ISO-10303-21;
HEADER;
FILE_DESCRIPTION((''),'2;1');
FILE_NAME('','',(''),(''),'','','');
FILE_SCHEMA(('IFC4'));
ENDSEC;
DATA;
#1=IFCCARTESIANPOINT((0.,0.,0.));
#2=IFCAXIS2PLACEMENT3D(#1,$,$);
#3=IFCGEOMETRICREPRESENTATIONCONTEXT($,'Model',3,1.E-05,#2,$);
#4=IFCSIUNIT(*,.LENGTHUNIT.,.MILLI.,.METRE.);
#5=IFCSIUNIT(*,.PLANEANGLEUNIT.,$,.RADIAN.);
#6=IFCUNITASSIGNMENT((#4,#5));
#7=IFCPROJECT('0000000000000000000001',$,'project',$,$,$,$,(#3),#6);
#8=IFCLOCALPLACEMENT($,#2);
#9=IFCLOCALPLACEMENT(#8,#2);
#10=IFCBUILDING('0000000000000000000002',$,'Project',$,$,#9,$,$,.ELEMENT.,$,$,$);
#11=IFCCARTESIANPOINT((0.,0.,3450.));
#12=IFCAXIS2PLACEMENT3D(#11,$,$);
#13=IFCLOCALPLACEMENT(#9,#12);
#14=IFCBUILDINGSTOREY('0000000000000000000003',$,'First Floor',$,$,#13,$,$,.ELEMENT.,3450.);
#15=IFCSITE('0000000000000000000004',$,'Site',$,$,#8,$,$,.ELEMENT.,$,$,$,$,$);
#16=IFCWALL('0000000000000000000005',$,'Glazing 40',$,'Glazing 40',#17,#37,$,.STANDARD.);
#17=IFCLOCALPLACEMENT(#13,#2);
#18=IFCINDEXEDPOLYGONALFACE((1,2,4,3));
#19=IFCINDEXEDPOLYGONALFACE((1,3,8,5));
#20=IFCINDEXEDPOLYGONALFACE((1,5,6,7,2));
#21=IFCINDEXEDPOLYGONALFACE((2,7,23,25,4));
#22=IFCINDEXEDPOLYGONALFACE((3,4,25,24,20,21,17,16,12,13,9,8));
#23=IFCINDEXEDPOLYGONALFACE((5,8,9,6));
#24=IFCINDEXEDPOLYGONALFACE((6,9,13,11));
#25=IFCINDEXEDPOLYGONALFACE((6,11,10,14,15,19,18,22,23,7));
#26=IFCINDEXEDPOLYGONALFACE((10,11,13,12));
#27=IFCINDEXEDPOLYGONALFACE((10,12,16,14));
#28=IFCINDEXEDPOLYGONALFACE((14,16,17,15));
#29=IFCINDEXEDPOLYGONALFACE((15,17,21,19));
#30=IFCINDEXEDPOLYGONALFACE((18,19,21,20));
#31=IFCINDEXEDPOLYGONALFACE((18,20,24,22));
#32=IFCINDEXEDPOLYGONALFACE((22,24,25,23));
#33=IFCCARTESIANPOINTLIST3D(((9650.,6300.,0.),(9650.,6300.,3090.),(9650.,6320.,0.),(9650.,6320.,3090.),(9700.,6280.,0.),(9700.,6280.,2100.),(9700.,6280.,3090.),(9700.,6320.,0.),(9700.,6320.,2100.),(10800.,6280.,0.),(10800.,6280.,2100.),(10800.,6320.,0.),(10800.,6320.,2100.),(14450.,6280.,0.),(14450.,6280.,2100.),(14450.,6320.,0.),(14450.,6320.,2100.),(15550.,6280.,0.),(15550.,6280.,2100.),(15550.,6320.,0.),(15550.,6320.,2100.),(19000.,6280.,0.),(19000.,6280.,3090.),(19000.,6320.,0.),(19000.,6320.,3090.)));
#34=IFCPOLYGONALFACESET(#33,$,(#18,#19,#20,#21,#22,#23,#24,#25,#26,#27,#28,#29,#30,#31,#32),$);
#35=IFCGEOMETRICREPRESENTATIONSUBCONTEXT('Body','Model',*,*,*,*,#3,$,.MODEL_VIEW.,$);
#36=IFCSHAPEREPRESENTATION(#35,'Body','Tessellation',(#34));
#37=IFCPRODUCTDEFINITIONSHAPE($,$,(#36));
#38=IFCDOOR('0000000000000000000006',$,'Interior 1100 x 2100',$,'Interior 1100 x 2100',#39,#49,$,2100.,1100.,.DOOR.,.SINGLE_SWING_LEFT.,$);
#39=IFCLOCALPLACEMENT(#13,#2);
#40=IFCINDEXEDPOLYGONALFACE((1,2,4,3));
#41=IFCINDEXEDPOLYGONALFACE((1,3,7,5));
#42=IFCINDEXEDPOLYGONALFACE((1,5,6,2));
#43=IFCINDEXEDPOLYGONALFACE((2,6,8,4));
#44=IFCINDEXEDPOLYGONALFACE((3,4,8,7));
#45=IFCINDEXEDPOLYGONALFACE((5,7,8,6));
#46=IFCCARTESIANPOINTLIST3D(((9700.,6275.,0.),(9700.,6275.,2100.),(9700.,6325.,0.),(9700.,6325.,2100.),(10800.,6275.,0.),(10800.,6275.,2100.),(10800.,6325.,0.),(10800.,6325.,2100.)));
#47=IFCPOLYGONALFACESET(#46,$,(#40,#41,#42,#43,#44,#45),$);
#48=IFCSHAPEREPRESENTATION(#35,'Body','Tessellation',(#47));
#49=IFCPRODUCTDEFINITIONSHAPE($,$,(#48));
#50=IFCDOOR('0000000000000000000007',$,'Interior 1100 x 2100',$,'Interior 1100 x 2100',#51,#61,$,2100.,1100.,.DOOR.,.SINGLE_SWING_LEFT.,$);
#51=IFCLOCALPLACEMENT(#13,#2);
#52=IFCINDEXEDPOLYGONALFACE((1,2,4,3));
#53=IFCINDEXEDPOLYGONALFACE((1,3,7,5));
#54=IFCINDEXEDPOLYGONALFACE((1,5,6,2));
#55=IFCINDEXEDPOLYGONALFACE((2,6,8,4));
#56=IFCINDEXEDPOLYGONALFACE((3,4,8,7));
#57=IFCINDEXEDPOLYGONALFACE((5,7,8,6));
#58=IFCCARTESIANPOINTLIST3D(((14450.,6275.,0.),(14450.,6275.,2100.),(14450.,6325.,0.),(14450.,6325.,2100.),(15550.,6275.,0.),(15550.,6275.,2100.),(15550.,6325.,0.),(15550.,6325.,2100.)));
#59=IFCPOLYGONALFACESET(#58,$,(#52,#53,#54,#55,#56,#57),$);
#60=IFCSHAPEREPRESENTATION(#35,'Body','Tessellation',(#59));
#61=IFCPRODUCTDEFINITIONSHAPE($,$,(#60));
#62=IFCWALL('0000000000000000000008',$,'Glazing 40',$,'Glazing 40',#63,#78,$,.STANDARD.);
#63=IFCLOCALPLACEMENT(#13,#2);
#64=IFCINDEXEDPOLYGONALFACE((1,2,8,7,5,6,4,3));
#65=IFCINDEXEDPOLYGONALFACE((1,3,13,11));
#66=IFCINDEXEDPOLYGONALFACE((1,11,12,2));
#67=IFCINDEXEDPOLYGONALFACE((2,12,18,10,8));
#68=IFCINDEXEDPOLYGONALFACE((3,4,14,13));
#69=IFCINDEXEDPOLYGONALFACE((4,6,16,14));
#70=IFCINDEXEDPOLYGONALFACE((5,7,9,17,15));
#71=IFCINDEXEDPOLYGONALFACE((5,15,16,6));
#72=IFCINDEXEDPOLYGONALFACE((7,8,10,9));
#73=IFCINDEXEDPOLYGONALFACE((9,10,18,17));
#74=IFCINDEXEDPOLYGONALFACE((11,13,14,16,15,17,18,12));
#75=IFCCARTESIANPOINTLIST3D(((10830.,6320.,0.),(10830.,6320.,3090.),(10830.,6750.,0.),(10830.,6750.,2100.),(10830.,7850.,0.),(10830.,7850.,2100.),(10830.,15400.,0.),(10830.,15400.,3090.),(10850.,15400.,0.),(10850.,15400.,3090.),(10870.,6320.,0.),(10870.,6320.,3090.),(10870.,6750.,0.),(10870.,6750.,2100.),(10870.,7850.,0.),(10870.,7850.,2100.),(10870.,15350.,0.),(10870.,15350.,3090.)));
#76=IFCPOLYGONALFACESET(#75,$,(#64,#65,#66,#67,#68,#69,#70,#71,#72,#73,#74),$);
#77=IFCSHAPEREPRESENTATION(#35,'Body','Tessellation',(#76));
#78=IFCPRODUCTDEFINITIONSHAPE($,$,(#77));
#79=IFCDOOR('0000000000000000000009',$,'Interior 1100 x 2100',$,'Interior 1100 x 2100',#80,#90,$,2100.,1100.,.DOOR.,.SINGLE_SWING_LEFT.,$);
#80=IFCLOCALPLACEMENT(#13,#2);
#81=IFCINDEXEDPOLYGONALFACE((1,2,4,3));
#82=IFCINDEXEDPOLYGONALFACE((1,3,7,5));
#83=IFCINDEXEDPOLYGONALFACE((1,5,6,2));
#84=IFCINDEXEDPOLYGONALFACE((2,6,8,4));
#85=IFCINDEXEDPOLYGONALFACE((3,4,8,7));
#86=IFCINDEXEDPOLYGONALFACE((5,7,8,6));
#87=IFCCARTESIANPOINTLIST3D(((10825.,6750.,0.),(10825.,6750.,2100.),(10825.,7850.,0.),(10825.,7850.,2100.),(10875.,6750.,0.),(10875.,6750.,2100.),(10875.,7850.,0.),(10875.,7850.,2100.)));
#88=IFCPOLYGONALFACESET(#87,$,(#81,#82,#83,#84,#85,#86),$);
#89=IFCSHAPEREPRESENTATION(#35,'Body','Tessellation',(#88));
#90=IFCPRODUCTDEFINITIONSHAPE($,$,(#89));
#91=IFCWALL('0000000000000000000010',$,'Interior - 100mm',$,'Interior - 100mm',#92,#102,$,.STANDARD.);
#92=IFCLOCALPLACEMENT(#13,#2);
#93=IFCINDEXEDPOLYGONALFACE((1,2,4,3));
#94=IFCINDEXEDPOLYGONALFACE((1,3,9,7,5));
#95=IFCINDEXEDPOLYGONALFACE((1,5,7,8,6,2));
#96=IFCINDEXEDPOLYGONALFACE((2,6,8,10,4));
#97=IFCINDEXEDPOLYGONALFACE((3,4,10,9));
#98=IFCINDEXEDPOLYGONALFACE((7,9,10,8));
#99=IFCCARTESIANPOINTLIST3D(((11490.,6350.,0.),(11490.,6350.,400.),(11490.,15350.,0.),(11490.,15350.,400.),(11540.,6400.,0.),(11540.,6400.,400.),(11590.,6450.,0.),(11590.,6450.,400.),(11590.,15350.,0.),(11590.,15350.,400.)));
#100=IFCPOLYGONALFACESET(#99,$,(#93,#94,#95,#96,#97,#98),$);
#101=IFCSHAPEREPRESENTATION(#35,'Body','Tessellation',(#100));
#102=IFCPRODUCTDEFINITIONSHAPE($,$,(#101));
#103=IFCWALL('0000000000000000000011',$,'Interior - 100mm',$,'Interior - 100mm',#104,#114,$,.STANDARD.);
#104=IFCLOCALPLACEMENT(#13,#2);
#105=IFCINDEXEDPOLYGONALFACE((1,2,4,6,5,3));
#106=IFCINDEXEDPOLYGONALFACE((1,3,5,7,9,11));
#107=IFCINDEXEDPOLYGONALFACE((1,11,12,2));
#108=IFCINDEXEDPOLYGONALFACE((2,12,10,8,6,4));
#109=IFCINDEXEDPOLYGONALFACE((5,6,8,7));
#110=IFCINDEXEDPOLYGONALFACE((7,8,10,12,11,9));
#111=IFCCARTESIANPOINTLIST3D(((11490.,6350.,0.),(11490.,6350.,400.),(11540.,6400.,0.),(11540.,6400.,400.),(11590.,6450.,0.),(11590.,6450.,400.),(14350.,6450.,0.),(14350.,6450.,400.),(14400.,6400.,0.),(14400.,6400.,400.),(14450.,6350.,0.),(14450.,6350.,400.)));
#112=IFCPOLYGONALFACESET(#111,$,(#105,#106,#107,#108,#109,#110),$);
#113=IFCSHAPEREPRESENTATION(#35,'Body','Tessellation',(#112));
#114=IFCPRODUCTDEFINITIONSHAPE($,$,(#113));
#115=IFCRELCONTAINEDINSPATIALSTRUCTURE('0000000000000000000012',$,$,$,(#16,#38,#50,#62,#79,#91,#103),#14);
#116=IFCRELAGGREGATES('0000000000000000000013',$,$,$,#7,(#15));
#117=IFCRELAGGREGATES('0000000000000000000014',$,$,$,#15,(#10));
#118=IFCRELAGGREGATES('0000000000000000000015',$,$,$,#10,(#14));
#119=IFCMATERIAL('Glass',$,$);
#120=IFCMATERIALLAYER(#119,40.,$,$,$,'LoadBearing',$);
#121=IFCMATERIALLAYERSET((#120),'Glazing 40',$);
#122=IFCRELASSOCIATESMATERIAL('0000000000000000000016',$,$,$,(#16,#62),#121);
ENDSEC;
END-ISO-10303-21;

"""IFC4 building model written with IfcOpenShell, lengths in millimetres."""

from ifc_helpers import new_model, si_unit, frame, frame_2d, origin, place, context, subcontext, project, spatial, polyline, rectangle, outline, extrude, material, layer, layer_set, layer_usage, element, fill, save


model = new_model("IFC4")

# Units and contexts
model_context = context("Model", 3, precision=1e-05, world=origin())
body_context = subcontext(model_context, "Body", "Model", "MODEL_VIEW")
ifc_project = project(units=[si_unit("LENGTHUNIT", "METRE", prefix="MILLI"), si_unit("PLANEANGLEUNIT", "RADIAN")], contexts=[model_context])

# Site, building, storey
site_placement = place(None, origin())
site = spatial("IfcSite", under=ifc_project, at=site_placement, Name="Site", CompositionType="ELEMENT")
building_placement = place(site_placement, origin())
building = spatial("IfcBuilding", under=site, at=building_placement, Name="Project", CompositionType="ELEMENT")
storey_placement = place(building_placement, frame((0.0, 0.0, 3450.0)))
storey = spatial("IfcBuildingStorey", under=building, at=storey_placement, Name="First Floor", CompositionType="ELEMENT", Elevation=3450.0)

# Wall, openings, doors
ifc_material_1 = material(Name="Glass")
ifc_layer_1 = layer(ifc_material_1, 40.0, Category="LoadBearing")
ifc_layer_set_1 = layer_set([ifc_layer_1], Name="Glazing 40")
ifc_layer_usage_1 = layer_usage(ifc_layer_set_1, "AXIS2", "NEGATIVE", 20.0)
wall_1_placement = place(storey_placement, frame((9650.0, 6300.0, 0.0), z_axis=(0.0, 0.0, 1.0), x_axis=(1.0, 0.0, 0.0)))
wall_1 = element("IfcWall", 1, at=wall_1_placement, inside=storey, material=ifc_layer_usage_1, Name="Glazing 40", ObjectType="Glazing 40", PredefinedType="STANDARD", context=body_context, shape_type="SweptSolid", body=[
    extrude(outline(polyline([(50.0, -20.0), (0.0, 0.0), (0.0, 20.0), (9350.0, 20.0), (9350.0, -20.0), (50.0, -20.0)])), origin(), (0.0, 0.0, 1.0), 3090.0),
])
opening_1_placement = place(wall_1_placement, frame((50.0, 0.0, 0.0), z_axis=(0.0, 0.0, 1.0), x_axis=(1.0, 0.0, 0.0)))
opening_1 = element("IfcOpeningElement", 2, at=opening_1_placement, cuts=wall_1, PredefinedType="OPENING", context=body_context, shape_type="SweptSolid", body=[
    extrude(rectangle(XDim=1100.0, YDim=60.0, at=frame_2d((550.0, 0.0))), origin(), (0.0, 0.0, 1.0), 2100.0),
])
opening_2_placement = place(wall_1_placement, frame((4800.0, 0.0, 0.0), z_axis=(0.0, 0.0, 1.0), x_axis=(1.0, 0.0, 0.0)))
opening_2 = element("IfcOpeningElement", 3, at=opening_2_placement, cuts=wall_1, PredefinedType="OPENING", context=body_context, shape_type="SweptSolid", body=[
    extrude(rectangle(XDim=1100.0, YDim=60.0, at=frame_2d((550.0, 0.0))), origin(), (0.0, 0.0, 1.0), 2100.0),
])
door_1_placement = place(opening_1_placement, origin())
door_1 = element("IfcDoor", 4, at=door_1_placement, inside=storey, Name="Interior 1100 x 2100", ObjectType="Interior 1100 x 2100", OperationType="SINGLE_SWING_LEFT", OverallHeight=2100.0, OverallWidth=1100.0, PredefinedType="DOOR", context=body_context, shape_type="SweptSolid", body=[
    extrude(rectangle(XDim=1100.0, YDim=50.0, at=frame_2d((550.0, 0.0))), origin(), (0.0, 0.0, 1.0), 2100.0),
])
fill(opening_1, door_1)
door_2_placement = place(opening_2_placement, origin())
door_2 = element("IfcDoor", 5, at=door_2_placement, inside=storey, Name="Interior 1100 x 2100", ObjectType="Interior 1100 x 2100", OperationType="SINGLE_SWING_LEFT", OverallHeight=2100.0, OverallWidth=1100.0, PredefinedType="DOOR", context=body_context, shape_type="SweptSolid", body=[
    extrude(rectangle(XDim=1100.0, YDim=50.0, at=frame_2d((550.0, 0.0))), origin(), (0.0, 0.0, 1.0), 2100.0),
])
fill(opening_2, door_2)

# Wall, opening, door
wall_2_placement = place(storey_placement, frame((10850.0, 6300.0, 0.0), z_axis=(0.0, 0.0, 1.0), x_axis=(0.0, 1.0, 0.0)))
wall_2 = element("IfcWall", 6, at=wall_2_placement, inside=storey, material=ifc_layer_usage_1, Name="Glazing 40", ObjectType="Glazing 40", PredefinedType="STANDARD", context=body_context, shape_type="SweptSolid", body=[
    extrude(outline(polyline([(20.0, -20.0), (20.0, 20.0), (9100.0, 20.0), (9100.0, 0.0), (9050.0, -20.0), (20.0, -20.0)])), origin(), (0.0, 0.0, 1.0), 3090.0),
])
opening_3_placement = place(wall_2_placement, frame((450.0, 0.0, 0.0), z_axis=(0.0, 0.0, 1.0), x_axis=(1.0, 0.0, 0.0)))
opening_3 = element("IfcOpeningElement", 7, at=opening_3_placement, cuts=wall_2, PredefinedType="OPENING", context=body_context, shape_type="SweptSolid", body=[
    extrude(rectangle(XDim=1100.0, YDim=60.0, at=frame_2d((550.0, 0.0))), origin(), (0.0, 0.0, 1.0), 2100.0),
])
door_3_placement = place(opening_3_placement, origin())
door_3 = element("IfcDoor", 8, at=door_3_placement, inside=storey, Name="Interior 1100 x 2100", ObjectType="Interior 1100 x 2100", OperationType="SINGLE_SWING_LEFT", OverallHeight=2100.0, OverallWidth=1100.0, PredefinedType="DOOR", context=body_context, shape_type="SweptSolid", body=[
    extrude(rectangle(XDim=1100.0, YDim=50.0, at=frame_2d((550.0, 0.0))), origin(), (0.0, 0.0, 1.0), 2100.0),
])
fill(opening_3, door_3)

# Walls
wall_3_placement = place(storey_placement, frame((11540.0, 6400.0, 0.0), z_axis=(0.0, 0.0, 1.0), x_axis=(0.0, 1.0, 0.0)))
element("IfcWall", 9, at=wall_3_placement, inside=storey, Name="Interior - 100mm", ObjectType="Interior - 100mm", PredefinedType="STANDARD", context=body_context, shape_type="SweptSolid", body=[
    extrude(outline(polyline([(50.0, -50.0), (0.0, 0.0), (-50.0, 50.0), (8950.0, 50.0), (8950.0, -50.0), (50.0, -50.0)])), origin(), (0.0, 0.0, 1.0), 400.0),
])
wall_4_placement = place(storey_placement, frame((14400.0, 6400.0, 0.0), z_axis=(0.0, 0.0, 1.0), x_axis=(-1.0, 0.0, 0.0)))
element("IfcWall", 10, at=wall_4_placement, inside=storey, Name="Interior - 100mm", ObjectType="Interior - 100mm", PredefinedType="STANDARD", context=body_context, shape_type="SweptSolid", body=[
    extrude(outline(polyline([(50.0, -50.0), (0.0, 0.0), (-50.0, 50.0), (2910.0, 50.0), (2860.0, 0.0), (2810.0, -50.0), (50.0, -50.0)])), origin(), (0.0, 0.0, 1.0), 400.0),
])

save(model, "model.ifc")
